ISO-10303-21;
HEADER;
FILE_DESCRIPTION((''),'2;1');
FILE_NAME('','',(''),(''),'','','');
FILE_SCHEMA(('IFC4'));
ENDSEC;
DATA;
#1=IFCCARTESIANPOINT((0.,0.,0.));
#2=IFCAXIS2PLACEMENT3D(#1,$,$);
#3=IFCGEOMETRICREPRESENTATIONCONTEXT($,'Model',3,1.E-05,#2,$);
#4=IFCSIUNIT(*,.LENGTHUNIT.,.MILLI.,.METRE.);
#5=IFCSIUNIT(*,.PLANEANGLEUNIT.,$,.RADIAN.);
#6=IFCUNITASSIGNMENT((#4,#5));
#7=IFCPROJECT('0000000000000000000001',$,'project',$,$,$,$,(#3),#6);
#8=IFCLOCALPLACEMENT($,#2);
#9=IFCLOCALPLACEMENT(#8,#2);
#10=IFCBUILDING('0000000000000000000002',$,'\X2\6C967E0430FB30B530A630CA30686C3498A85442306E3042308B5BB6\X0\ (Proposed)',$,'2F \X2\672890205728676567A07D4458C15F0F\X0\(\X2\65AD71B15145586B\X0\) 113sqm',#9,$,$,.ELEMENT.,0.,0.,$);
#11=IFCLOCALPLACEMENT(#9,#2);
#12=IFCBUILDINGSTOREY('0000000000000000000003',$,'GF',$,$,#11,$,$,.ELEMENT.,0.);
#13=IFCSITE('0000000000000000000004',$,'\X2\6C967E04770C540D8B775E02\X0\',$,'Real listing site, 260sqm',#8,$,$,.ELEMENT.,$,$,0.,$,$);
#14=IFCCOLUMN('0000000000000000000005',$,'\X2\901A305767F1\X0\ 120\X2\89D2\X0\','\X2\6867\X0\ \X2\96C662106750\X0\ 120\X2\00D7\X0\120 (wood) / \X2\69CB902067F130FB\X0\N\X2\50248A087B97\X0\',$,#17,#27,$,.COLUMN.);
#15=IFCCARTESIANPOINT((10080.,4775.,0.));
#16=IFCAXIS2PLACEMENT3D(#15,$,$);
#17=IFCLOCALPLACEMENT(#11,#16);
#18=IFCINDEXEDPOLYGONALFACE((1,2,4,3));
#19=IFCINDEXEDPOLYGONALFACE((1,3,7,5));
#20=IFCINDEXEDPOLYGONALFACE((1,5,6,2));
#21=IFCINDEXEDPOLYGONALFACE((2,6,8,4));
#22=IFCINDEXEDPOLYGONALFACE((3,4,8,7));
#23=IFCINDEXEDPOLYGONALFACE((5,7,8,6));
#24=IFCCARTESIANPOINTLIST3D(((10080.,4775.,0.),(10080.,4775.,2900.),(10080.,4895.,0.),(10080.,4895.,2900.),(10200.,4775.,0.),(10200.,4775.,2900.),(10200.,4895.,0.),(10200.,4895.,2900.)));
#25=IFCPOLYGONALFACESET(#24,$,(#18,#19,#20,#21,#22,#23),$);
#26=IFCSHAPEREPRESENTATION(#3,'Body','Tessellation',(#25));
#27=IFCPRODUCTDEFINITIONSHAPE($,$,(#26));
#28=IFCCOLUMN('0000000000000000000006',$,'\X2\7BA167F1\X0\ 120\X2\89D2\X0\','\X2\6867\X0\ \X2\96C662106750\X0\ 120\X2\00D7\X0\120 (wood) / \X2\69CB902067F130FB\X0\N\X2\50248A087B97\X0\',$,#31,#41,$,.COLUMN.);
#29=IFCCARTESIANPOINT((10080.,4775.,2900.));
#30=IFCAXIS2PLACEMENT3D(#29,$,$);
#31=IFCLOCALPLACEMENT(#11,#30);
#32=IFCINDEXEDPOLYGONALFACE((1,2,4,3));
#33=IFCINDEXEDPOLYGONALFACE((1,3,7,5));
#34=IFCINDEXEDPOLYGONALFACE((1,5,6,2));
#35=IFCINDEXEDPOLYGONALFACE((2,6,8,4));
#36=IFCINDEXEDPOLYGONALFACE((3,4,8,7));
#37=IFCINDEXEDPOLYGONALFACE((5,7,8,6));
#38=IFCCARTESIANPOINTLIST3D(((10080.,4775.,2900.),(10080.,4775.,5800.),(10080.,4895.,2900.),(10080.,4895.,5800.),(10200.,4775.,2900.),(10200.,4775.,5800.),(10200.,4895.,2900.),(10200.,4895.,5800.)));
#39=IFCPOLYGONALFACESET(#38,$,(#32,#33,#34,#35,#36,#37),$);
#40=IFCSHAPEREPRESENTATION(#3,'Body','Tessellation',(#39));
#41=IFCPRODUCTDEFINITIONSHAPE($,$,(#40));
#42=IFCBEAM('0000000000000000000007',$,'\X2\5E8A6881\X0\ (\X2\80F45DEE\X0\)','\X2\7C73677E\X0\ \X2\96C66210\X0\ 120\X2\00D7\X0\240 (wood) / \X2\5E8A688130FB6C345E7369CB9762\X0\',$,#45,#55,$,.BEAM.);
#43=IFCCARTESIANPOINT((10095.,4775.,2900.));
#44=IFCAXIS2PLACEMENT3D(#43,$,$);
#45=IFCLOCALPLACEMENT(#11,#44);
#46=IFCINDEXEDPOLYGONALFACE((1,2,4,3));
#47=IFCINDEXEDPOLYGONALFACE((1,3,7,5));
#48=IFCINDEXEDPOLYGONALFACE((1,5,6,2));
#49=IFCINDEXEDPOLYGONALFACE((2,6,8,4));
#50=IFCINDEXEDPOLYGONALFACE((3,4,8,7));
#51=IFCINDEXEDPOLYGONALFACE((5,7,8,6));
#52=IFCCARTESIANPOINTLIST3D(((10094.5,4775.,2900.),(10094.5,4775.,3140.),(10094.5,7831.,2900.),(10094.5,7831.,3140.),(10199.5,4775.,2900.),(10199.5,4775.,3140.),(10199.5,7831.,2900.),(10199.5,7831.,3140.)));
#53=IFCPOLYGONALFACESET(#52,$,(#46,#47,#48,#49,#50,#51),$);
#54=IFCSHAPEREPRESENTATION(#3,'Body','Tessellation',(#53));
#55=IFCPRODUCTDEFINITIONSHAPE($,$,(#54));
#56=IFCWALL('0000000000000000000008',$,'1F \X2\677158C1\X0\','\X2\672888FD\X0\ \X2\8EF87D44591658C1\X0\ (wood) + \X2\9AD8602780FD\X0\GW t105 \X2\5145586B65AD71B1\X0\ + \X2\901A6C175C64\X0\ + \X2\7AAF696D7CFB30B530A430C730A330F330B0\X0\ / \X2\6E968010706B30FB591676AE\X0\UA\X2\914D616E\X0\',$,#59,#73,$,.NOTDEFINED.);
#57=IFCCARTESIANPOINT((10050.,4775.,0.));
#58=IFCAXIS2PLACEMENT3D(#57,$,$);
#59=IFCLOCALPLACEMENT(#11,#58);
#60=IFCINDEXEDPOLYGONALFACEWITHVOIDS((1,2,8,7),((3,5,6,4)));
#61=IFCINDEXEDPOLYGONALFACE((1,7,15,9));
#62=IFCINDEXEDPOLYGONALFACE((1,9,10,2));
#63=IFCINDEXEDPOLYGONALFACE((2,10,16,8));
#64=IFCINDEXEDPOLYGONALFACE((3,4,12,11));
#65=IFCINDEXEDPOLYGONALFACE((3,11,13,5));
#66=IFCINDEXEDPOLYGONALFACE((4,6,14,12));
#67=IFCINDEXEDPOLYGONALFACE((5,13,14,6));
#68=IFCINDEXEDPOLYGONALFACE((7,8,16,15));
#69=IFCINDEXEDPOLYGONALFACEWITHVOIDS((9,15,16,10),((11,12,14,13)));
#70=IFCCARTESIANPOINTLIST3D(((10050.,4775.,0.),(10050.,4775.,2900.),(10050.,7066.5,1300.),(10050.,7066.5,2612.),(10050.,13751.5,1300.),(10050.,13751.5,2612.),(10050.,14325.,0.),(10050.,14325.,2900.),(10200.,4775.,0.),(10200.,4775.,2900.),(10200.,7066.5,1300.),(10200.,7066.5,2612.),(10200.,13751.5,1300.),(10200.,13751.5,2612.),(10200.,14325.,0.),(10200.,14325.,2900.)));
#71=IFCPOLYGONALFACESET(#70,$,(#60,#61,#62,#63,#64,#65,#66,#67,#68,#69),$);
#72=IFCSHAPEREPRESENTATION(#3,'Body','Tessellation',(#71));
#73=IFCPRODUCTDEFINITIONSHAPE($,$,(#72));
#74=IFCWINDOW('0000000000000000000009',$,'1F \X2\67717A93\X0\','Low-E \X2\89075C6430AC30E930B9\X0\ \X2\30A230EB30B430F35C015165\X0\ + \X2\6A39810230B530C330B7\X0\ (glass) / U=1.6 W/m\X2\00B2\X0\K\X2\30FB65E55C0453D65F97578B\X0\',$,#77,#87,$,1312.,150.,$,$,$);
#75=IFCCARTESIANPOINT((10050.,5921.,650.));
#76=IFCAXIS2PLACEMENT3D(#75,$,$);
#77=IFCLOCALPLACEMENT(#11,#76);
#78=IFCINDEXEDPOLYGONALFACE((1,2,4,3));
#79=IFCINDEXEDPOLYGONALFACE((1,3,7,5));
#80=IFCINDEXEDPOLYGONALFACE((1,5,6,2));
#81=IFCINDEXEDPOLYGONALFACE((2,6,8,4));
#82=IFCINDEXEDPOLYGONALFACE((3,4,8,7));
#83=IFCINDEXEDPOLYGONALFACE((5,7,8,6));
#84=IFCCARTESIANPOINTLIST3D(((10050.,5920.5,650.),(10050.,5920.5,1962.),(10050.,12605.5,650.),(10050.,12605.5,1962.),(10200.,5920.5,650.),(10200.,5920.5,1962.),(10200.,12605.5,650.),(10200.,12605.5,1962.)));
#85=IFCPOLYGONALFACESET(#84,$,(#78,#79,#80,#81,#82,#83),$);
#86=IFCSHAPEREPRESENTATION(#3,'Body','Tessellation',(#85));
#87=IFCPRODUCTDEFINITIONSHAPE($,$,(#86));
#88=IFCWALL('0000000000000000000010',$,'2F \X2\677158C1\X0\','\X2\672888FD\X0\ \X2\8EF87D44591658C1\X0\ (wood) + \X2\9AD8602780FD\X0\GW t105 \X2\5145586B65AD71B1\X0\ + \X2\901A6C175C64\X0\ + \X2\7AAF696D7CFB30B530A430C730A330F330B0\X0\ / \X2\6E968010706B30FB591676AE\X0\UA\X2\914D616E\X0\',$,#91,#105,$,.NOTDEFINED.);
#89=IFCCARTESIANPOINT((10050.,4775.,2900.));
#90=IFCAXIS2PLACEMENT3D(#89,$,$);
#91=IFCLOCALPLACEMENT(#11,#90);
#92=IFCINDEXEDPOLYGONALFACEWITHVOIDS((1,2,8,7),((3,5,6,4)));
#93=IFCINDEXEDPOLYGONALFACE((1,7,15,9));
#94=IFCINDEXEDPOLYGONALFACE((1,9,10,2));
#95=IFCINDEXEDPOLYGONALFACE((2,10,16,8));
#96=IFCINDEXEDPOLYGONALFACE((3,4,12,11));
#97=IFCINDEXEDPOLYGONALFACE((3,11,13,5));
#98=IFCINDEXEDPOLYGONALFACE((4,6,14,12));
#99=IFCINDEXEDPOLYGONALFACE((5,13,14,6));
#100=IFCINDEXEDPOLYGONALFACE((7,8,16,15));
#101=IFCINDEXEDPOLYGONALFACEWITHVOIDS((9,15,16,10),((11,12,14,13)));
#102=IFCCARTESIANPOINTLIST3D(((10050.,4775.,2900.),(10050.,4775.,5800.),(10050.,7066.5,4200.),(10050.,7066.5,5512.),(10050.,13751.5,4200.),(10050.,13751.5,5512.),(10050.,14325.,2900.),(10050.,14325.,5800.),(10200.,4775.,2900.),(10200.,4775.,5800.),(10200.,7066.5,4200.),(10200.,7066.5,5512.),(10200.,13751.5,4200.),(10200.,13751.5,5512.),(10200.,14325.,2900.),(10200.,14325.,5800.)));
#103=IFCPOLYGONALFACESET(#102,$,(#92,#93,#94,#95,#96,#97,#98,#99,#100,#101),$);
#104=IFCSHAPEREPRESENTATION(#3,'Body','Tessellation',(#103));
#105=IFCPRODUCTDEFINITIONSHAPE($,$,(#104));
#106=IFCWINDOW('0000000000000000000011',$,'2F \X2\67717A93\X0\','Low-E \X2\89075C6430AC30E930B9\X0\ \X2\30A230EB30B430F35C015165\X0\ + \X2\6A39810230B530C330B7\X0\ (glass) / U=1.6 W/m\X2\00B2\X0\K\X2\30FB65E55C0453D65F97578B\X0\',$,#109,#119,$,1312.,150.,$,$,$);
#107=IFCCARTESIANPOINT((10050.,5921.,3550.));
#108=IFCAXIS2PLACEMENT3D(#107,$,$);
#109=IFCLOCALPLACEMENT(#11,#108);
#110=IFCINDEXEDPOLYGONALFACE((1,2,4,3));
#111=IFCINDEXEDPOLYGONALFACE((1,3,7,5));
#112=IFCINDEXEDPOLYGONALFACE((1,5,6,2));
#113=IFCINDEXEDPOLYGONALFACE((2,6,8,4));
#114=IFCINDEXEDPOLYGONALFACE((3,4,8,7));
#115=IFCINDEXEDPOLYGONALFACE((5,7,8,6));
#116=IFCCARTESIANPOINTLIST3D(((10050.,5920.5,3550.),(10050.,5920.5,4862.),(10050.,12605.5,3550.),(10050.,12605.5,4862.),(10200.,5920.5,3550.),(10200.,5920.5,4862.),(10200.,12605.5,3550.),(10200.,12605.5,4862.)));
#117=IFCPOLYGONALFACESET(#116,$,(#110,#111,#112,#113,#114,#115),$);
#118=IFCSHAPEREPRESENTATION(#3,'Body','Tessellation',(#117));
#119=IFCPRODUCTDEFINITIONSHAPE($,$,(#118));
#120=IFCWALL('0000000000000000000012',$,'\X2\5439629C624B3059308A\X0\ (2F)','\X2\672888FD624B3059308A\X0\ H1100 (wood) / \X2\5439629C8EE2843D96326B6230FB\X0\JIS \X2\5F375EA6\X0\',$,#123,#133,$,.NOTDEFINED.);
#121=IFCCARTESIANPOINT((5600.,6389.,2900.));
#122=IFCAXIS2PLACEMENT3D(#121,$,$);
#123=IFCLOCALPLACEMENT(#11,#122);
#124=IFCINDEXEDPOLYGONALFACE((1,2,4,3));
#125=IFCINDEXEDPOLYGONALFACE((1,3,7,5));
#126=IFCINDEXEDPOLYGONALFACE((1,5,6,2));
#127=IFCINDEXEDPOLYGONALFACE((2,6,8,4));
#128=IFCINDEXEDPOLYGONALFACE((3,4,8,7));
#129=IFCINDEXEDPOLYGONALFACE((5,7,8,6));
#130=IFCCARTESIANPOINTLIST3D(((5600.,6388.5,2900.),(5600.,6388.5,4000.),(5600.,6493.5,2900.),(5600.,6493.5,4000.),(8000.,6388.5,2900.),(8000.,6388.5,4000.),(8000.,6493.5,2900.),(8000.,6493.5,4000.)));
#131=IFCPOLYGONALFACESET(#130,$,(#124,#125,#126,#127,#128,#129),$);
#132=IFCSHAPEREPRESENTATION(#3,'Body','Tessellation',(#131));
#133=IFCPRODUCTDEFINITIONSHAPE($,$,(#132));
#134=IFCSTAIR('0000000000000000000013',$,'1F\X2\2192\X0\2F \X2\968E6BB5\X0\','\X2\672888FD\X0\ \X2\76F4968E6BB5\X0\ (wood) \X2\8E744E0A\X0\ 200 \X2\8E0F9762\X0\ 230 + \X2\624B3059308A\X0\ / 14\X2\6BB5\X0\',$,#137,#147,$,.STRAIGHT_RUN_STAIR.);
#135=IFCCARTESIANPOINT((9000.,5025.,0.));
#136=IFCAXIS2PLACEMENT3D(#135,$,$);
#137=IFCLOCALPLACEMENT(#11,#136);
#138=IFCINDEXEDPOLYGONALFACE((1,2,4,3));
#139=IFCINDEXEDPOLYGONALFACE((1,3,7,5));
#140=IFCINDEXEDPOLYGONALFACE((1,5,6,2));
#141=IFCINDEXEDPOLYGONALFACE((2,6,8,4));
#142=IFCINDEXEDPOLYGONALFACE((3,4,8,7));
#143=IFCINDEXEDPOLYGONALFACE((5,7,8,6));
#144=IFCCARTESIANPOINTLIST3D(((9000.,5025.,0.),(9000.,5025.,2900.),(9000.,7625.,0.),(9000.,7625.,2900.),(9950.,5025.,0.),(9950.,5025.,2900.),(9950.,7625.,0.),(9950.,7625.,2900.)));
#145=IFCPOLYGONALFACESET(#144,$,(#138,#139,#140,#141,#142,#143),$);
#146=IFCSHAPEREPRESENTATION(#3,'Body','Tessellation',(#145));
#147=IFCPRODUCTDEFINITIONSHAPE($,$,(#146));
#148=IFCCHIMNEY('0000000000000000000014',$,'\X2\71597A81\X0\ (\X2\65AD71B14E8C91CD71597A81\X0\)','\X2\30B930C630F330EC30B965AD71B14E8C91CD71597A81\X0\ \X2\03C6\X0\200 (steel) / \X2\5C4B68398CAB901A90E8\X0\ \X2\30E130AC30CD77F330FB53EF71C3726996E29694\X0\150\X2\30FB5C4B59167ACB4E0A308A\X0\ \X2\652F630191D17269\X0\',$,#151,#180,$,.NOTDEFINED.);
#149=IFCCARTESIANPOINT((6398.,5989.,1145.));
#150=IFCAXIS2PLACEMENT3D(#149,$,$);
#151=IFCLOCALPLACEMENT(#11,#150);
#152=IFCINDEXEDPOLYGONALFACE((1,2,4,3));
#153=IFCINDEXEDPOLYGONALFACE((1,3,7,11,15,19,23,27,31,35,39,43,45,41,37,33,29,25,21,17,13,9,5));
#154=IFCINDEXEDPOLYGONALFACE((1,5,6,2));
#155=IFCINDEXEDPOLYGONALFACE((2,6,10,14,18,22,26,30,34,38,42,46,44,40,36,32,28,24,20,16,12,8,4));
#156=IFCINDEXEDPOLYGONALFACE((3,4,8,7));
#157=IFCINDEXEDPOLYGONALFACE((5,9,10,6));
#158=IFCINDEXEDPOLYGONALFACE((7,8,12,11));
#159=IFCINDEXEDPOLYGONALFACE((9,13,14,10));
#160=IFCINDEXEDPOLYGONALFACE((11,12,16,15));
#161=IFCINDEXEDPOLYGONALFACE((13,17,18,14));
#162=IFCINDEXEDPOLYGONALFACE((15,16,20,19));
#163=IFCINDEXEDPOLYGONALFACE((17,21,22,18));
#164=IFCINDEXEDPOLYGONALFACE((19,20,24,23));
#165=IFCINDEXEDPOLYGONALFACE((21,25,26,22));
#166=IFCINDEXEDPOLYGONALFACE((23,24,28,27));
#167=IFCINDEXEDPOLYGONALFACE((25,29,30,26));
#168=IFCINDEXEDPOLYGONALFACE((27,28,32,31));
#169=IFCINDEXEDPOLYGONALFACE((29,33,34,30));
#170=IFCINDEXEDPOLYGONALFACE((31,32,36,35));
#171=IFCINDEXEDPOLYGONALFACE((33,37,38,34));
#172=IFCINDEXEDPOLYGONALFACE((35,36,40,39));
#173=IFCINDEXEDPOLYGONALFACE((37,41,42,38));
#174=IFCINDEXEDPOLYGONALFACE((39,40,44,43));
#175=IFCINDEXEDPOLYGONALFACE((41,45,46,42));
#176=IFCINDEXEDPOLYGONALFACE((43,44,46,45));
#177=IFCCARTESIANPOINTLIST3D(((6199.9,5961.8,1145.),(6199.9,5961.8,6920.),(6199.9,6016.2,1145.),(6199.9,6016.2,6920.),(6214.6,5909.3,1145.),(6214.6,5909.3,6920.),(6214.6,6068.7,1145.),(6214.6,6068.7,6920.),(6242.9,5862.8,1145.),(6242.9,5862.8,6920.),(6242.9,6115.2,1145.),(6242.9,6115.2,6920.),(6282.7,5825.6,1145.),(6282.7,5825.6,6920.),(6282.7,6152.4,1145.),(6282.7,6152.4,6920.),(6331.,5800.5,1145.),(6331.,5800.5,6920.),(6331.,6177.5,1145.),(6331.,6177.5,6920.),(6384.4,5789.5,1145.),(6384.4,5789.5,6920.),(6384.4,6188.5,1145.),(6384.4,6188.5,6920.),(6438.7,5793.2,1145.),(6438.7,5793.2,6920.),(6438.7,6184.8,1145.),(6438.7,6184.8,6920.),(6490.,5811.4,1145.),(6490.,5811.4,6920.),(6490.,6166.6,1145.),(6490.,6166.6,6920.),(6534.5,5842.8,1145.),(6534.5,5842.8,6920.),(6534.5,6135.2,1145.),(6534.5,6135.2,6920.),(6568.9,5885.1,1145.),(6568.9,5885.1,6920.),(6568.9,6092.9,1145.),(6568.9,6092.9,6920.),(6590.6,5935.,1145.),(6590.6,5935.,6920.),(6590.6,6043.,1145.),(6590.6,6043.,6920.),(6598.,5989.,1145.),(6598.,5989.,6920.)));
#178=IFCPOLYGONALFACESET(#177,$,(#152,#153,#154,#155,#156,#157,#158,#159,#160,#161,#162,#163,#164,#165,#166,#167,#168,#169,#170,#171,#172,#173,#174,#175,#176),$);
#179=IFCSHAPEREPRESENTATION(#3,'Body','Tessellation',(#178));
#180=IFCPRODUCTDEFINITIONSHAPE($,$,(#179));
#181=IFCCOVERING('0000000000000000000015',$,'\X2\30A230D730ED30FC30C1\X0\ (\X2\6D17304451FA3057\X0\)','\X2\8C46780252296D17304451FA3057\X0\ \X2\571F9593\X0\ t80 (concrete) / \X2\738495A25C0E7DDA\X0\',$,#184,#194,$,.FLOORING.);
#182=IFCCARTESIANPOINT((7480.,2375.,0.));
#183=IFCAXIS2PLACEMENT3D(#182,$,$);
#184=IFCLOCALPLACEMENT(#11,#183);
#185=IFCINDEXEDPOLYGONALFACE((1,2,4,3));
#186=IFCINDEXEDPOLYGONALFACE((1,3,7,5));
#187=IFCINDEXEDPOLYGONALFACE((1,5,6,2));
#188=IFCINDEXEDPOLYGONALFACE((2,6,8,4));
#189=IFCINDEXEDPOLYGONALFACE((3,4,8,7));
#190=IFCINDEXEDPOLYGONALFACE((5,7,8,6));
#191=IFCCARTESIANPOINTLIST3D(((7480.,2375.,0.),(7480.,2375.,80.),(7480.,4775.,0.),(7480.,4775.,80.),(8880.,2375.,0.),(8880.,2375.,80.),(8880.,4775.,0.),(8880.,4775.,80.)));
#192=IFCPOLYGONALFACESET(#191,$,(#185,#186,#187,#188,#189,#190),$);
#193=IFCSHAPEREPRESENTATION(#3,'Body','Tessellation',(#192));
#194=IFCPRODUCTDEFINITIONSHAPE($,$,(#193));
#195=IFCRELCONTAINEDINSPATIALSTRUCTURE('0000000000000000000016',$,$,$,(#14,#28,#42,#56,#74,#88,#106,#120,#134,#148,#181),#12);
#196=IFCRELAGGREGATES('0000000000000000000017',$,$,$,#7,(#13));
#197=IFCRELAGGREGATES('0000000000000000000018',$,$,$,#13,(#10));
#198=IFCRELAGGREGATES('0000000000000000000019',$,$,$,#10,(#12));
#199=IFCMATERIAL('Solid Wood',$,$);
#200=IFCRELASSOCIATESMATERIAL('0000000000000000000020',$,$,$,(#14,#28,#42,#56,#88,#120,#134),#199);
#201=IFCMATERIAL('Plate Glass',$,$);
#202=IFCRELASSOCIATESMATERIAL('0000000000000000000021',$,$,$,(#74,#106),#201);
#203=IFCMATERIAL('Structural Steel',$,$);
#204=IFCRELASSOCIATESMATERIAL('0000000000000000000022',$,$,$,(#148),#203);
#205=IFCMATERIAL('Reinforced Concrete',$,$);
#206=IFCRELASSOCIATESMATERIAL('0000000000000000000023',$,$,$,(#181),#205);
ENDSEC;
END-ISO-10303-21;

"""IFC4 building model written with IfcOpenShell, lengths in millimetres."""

from ifc_helpers import new_model, si_unit, frame, frame_2d, origin, origin_2d, place, context, project, spatial, rectangle, circle, extrude, material, element, fill, save


model = new_model("IFC4")

# Units and contexts
model_context = context("Model", 3, precision=1e-05, world=origin())
ifc_project = project(units=[si_unit("LENGTHUNIT", "METRE", prefix="MILLI"), si_unit("PLANEANGLEUNIT", "RADIAN")], contexts=[model_context])

# Site, building, storey
site_placement = place(None, origin())
site = spatial("IfcSite", under=ifc_project, at=site_placement, Name="沖縄県名護市", ObjectType="Real listing site, 260sqm", CompositionType="ELEMENT", RefElevation=0.0)
building_placement = place(site_placement, origin())
building = spatial("IfcBuilding", under=site, at=building_placement, Name="沖縄・サウナと水風呂のある家 (Proposed)", ObjectType="2F 木造在来枠組壁式(断熱充填) 113sqm", CompositionType="ELEMENT", ElevationOfRefHeight=0.0, ElevationOfTerrain=0.0)
storey_placement = place(building_placement, origin())
storey = spatial("IfcBuildingStorey", under=building, at=storey_placement, Name="GF", CompositionType="ELEMENT", Elevation=0.0)

# Columns
ifc_material_1 = material(Name="Solid Wood")
column_1_placement = place(storey_placement, frame((10080.0, 4775.0, 0.0)))
element("IfcColumn", 1, at=column_1_placement, inside=storey, material=ifc_material_1, Name="通し柱 120角", Description="桧 集成材 120×120 (wood) / 構造柱・N値計算", PredefinedType="COLUMN", context=model_context, shape_type="SweptSolid", body=[
    extrude(rectangle(XDim=120.0, YDim=120.0, at=frame_2d((60.0, 60.0))), frame((10080.0, 4775.0, 0.0)), (0.0, 0.0, 1.0), 2900.0),
])
column_2_placement = place(storey_placement, frame((10080.0, 4775.0, 2900.0)))
element("IfcColumn", 2, at=column_2_placement, inside=storey, material=ifc_material_1, Name="管柱 120角", Description="桧 集成材 120×120 (wood) / 構造柱・N値計算", PredefinedType="COLUMN", context=model_context, shape_type="SweptSolid", body=[
    extrude(rectangle(XDim=120.0, YDim=120.0, at=frame_2d((60.0, 60.0))), frame((10080.0, 4775.0, 2900.0)), (0.0, 0.0, 1.0), 2900.0),
])

# Beam
beam_1_placement = place(storey_placement, frame((10095.0, 4775.0, 2900.0)))
element("IfcBeam", 3, at=beam_1_placement, inside=storey, material=ifc_material_1, Name="床梁 (胴差)", Description="米松 集成 120×240 (wood) / 床梁・水平構面", PredefinedType="BEAM", context=model_context, shape_type="SweptSolid", body=[
    extrude(rectangle(XDim=105.0, YDim=3056.0, at=frame_2d((52.0, 1528.0))), frame((10095.0, 4775.0, 2900.0)), (0.0, 0.0, 1.0), 240.0),
])

# Wall, opening, window
wall_1_placement = place(storey_placement, frame((10050.0, 4775.0, 0.0)))
wall_1 = element("IfcWall", 4, at=wall_1_placement, inside=storey, material=ifc_material_1, Name="1F 東壁", Description="木製 軸組外壁 (wood) + 高性能GW t105 充填断熱 + 通気層 + 窯業系サイディング / 準耐火・外皮UA配慮", PredefinedType="NOTDEFINED", context=model_context, shape_type="SweptSolid", body=[
    extrude(rectangle(XDim=150.0, YDim=9550.0, at=frame_2d((75.0, 4775.0))), frame((10050.0, 4775.0, 0.0)), (0.0, 0.0, 1.0), 2900.0),
])
opening_1_placement = place(storey_placement, frame((10050.0, 5921.0, 650.0)))
opening_1 = element("IfcOpeningElement", 5, at=opening_1_placement, cuts=wall_1, PredefinedType="NOTDEFINED", context=model_context, shape_type="SweptSolid", body=[
    extrude(rectangle(XDim=150.0, YDim=6685.0, at=frame_2d((75.0, 3342.0))), frame((10050.0, 5921.0, 650.0)), (0.0, 0.0, 1.0), 1312.0),
])
ifc_material_2 = material(Name="Plate Glass")
window_1_placement = place(storey_placement, frame((10050.0, 5921.0, 650.0)))
window_1 = element("IfcWindow", 6, at=window_1_placement, inside=storey, material=ifc_material_2, Name="1F 東窓", Description="Low-E 複層ガラス アルゴン封入 + 樹脂サッシ (glass) / U=1.6 W/m²K・日射取得型", OverallHeight=1312.0, OverallWidth=150.0, context=model_context, shape_type="SweptSolid", body=[
    extrude(rectangle(XDim=150.0, YDim=6685.0, at=frame_2d((75.0, 3342.0))), frame((10050.0, 5921.0, 650.0)), (0.0, 0.0, 1.0), 1312.0),
])
fill(opening_1, window_1)

# Wall, opening, window
wall_2_placement = place(storey_placement, frame((10050.0, 4775.0, 2900.0)))
wall_2 = element("IfcWall", 7, at=wall_2_placement, inside=storey, material=ifc_material_1, Name="2F 東壁", Description="木製 軸組外壁 (wood) + 高性能GW t105 充填断熱 + 通気層 + 窯業系サイディング / 準耐火・外皮UA配慮", PredefinedType="NOTDEFINED", context=model_context, shape_type="SweptSolid", body=[
    extrude(rectangle(XDim=150.0, YDim=9550.0, at=frame_2d((75.0, 4775.0))), frame((10050.0, 4775.0, 2900.0)), (0.0, 0.0, 1.0), 2900.0),
])
opening_2_placement = place(storey_placement, frame((10050.0, 5921.0, 3550.0)))
opening_2 = element("IfcOpeningElement", 8, at=opening_2_placement, cuts=wall_2, PredefinedType="NOTDEFINED", context=model_context, shape_type="SweptSolid", body=[
    extrude(rectangle(XDim=150.0, YDim=6685.0, at=frame_2d((75.0, 3342.0))), frame((10050.0, 5921.0, 3550.0)), (0.0, 0.0, 1.0), 1312.0),
])
window_2_placement = place(storey_placement, frame((10050.0, 5921.0, 3550.0)))
window_2 = element("IfcWindow", 9, at=window_2_placement, inside=storey, material=ifc_material_2, Name="2F 東窓", Description="Low-E 複層ガラス アルゴン封入 + 樹脂サッシ (glass) / U=1.6 W/m²K・日射取得型", OverallHeight=1312.0, OverallWidth=150.0, context=model_context, shape_type="SweptSolid", body=[
    extrude(rectangle(XDim=150.0, YDim=6685.0, at=frame_2d((75.0, 3342.0))), frame((10050.0, 5921.0, 3550.0)), (0.0, 0.0, 1.0), 1312.0),
])
fill(opening_2, window_2)

# Wall
wall_3_placement = place(storey_placement, frame((5600.0, 6389.0, 2900.0)))
element("IfcWall", 10, at=wall_3_placement, inside=storey, material=ifc_material_1, Name="吹抜手すり (2F)", Description="木製手すり H1100 (wood) / 吹抜転落防止・JIS 強度", PredefinedType="NOTDEFINED", context=model_context, shape_type="SweptSolid", body=[
    extrude(rectangle(XDim=2400.0, YDim=105.0, at=frame_2d((1200.0, 52.0))), frame((5600.0, 6389.0, 2900.0)), (0.0, 0.0, 1.0), 1100.0),
])

# Stair
stair_placement = place(storey_placement, frame((9000.0, 5025.0, 0.0)))
element("IfcStair", 11, at=stair_placement, inside=storey, material=ifc_material_1, Name="1F→2F 階段", Description="木製 直階段 (wood) 蹴上 200 踏面 230 + 手すり / 14段", PredefinedType="STRAIGHT_RUN_STAIR", context=model_context, shape_type="SweptSolid", body=[
    extrude(rectangle(XDim=950.0, YDim=2600.0, at=frame_2d((475.0, 1300.0))), frame((9000.0, 5025.0, 0.0)), (0.0, 0.0, 1.0), 2900.0),
])

# Chimney
ifc_material_3 = material(Name="Structural Steel")
chimney_placement = place(storey_placement, frame((6398.0, 5989.0, 1145.0)))
element("IfcChimney", 12, at=chimney_placement, inside=storey, material=ifc_material_3, Name="煙突 (断熱二重煙突)", Description="ステンレス断熱二重煙突 φ200 (steel) / 屋根貫通部 メガネ石・可燃物離隔150・屋外立上り 支持金物", PredefinedType="NOTDEFINED", context=model_context, shape_type="SweptSolid", body=[
    extrude(circle(Radius=200.0, at=origin_2d()), frame((6398.0, 5989.0, 1145.0)), (0.0, 0.0, 1.0), 5775.0),
])

# Covering
ifc_material_4 = material(Name="Reinforced Concrete")
covering_1_placement = place(storey_placement, frame((7480.0, 2375.0, 0.0)))
element("IfcCovering", 13, at=covering_1_placement, inside=storey, material=ifc_material_4, Name="アプローチ (洗い出し)", Description="豆砂利洗い出し 土間 t80 (concrete) / 玄関導線", PredefinedType="FLOORING", context=model_context, shape_type="SweptSolid", body=[
    extrude(rectangle(XDim=1400.0, YDim=2400.0, at=frame_2d((700.0, 1200.0))), frame((7480.0, 2375.0, 0.0)), (0.0, 0.0, 1.0), 80.0),
])

save(model, "model.ifc")
